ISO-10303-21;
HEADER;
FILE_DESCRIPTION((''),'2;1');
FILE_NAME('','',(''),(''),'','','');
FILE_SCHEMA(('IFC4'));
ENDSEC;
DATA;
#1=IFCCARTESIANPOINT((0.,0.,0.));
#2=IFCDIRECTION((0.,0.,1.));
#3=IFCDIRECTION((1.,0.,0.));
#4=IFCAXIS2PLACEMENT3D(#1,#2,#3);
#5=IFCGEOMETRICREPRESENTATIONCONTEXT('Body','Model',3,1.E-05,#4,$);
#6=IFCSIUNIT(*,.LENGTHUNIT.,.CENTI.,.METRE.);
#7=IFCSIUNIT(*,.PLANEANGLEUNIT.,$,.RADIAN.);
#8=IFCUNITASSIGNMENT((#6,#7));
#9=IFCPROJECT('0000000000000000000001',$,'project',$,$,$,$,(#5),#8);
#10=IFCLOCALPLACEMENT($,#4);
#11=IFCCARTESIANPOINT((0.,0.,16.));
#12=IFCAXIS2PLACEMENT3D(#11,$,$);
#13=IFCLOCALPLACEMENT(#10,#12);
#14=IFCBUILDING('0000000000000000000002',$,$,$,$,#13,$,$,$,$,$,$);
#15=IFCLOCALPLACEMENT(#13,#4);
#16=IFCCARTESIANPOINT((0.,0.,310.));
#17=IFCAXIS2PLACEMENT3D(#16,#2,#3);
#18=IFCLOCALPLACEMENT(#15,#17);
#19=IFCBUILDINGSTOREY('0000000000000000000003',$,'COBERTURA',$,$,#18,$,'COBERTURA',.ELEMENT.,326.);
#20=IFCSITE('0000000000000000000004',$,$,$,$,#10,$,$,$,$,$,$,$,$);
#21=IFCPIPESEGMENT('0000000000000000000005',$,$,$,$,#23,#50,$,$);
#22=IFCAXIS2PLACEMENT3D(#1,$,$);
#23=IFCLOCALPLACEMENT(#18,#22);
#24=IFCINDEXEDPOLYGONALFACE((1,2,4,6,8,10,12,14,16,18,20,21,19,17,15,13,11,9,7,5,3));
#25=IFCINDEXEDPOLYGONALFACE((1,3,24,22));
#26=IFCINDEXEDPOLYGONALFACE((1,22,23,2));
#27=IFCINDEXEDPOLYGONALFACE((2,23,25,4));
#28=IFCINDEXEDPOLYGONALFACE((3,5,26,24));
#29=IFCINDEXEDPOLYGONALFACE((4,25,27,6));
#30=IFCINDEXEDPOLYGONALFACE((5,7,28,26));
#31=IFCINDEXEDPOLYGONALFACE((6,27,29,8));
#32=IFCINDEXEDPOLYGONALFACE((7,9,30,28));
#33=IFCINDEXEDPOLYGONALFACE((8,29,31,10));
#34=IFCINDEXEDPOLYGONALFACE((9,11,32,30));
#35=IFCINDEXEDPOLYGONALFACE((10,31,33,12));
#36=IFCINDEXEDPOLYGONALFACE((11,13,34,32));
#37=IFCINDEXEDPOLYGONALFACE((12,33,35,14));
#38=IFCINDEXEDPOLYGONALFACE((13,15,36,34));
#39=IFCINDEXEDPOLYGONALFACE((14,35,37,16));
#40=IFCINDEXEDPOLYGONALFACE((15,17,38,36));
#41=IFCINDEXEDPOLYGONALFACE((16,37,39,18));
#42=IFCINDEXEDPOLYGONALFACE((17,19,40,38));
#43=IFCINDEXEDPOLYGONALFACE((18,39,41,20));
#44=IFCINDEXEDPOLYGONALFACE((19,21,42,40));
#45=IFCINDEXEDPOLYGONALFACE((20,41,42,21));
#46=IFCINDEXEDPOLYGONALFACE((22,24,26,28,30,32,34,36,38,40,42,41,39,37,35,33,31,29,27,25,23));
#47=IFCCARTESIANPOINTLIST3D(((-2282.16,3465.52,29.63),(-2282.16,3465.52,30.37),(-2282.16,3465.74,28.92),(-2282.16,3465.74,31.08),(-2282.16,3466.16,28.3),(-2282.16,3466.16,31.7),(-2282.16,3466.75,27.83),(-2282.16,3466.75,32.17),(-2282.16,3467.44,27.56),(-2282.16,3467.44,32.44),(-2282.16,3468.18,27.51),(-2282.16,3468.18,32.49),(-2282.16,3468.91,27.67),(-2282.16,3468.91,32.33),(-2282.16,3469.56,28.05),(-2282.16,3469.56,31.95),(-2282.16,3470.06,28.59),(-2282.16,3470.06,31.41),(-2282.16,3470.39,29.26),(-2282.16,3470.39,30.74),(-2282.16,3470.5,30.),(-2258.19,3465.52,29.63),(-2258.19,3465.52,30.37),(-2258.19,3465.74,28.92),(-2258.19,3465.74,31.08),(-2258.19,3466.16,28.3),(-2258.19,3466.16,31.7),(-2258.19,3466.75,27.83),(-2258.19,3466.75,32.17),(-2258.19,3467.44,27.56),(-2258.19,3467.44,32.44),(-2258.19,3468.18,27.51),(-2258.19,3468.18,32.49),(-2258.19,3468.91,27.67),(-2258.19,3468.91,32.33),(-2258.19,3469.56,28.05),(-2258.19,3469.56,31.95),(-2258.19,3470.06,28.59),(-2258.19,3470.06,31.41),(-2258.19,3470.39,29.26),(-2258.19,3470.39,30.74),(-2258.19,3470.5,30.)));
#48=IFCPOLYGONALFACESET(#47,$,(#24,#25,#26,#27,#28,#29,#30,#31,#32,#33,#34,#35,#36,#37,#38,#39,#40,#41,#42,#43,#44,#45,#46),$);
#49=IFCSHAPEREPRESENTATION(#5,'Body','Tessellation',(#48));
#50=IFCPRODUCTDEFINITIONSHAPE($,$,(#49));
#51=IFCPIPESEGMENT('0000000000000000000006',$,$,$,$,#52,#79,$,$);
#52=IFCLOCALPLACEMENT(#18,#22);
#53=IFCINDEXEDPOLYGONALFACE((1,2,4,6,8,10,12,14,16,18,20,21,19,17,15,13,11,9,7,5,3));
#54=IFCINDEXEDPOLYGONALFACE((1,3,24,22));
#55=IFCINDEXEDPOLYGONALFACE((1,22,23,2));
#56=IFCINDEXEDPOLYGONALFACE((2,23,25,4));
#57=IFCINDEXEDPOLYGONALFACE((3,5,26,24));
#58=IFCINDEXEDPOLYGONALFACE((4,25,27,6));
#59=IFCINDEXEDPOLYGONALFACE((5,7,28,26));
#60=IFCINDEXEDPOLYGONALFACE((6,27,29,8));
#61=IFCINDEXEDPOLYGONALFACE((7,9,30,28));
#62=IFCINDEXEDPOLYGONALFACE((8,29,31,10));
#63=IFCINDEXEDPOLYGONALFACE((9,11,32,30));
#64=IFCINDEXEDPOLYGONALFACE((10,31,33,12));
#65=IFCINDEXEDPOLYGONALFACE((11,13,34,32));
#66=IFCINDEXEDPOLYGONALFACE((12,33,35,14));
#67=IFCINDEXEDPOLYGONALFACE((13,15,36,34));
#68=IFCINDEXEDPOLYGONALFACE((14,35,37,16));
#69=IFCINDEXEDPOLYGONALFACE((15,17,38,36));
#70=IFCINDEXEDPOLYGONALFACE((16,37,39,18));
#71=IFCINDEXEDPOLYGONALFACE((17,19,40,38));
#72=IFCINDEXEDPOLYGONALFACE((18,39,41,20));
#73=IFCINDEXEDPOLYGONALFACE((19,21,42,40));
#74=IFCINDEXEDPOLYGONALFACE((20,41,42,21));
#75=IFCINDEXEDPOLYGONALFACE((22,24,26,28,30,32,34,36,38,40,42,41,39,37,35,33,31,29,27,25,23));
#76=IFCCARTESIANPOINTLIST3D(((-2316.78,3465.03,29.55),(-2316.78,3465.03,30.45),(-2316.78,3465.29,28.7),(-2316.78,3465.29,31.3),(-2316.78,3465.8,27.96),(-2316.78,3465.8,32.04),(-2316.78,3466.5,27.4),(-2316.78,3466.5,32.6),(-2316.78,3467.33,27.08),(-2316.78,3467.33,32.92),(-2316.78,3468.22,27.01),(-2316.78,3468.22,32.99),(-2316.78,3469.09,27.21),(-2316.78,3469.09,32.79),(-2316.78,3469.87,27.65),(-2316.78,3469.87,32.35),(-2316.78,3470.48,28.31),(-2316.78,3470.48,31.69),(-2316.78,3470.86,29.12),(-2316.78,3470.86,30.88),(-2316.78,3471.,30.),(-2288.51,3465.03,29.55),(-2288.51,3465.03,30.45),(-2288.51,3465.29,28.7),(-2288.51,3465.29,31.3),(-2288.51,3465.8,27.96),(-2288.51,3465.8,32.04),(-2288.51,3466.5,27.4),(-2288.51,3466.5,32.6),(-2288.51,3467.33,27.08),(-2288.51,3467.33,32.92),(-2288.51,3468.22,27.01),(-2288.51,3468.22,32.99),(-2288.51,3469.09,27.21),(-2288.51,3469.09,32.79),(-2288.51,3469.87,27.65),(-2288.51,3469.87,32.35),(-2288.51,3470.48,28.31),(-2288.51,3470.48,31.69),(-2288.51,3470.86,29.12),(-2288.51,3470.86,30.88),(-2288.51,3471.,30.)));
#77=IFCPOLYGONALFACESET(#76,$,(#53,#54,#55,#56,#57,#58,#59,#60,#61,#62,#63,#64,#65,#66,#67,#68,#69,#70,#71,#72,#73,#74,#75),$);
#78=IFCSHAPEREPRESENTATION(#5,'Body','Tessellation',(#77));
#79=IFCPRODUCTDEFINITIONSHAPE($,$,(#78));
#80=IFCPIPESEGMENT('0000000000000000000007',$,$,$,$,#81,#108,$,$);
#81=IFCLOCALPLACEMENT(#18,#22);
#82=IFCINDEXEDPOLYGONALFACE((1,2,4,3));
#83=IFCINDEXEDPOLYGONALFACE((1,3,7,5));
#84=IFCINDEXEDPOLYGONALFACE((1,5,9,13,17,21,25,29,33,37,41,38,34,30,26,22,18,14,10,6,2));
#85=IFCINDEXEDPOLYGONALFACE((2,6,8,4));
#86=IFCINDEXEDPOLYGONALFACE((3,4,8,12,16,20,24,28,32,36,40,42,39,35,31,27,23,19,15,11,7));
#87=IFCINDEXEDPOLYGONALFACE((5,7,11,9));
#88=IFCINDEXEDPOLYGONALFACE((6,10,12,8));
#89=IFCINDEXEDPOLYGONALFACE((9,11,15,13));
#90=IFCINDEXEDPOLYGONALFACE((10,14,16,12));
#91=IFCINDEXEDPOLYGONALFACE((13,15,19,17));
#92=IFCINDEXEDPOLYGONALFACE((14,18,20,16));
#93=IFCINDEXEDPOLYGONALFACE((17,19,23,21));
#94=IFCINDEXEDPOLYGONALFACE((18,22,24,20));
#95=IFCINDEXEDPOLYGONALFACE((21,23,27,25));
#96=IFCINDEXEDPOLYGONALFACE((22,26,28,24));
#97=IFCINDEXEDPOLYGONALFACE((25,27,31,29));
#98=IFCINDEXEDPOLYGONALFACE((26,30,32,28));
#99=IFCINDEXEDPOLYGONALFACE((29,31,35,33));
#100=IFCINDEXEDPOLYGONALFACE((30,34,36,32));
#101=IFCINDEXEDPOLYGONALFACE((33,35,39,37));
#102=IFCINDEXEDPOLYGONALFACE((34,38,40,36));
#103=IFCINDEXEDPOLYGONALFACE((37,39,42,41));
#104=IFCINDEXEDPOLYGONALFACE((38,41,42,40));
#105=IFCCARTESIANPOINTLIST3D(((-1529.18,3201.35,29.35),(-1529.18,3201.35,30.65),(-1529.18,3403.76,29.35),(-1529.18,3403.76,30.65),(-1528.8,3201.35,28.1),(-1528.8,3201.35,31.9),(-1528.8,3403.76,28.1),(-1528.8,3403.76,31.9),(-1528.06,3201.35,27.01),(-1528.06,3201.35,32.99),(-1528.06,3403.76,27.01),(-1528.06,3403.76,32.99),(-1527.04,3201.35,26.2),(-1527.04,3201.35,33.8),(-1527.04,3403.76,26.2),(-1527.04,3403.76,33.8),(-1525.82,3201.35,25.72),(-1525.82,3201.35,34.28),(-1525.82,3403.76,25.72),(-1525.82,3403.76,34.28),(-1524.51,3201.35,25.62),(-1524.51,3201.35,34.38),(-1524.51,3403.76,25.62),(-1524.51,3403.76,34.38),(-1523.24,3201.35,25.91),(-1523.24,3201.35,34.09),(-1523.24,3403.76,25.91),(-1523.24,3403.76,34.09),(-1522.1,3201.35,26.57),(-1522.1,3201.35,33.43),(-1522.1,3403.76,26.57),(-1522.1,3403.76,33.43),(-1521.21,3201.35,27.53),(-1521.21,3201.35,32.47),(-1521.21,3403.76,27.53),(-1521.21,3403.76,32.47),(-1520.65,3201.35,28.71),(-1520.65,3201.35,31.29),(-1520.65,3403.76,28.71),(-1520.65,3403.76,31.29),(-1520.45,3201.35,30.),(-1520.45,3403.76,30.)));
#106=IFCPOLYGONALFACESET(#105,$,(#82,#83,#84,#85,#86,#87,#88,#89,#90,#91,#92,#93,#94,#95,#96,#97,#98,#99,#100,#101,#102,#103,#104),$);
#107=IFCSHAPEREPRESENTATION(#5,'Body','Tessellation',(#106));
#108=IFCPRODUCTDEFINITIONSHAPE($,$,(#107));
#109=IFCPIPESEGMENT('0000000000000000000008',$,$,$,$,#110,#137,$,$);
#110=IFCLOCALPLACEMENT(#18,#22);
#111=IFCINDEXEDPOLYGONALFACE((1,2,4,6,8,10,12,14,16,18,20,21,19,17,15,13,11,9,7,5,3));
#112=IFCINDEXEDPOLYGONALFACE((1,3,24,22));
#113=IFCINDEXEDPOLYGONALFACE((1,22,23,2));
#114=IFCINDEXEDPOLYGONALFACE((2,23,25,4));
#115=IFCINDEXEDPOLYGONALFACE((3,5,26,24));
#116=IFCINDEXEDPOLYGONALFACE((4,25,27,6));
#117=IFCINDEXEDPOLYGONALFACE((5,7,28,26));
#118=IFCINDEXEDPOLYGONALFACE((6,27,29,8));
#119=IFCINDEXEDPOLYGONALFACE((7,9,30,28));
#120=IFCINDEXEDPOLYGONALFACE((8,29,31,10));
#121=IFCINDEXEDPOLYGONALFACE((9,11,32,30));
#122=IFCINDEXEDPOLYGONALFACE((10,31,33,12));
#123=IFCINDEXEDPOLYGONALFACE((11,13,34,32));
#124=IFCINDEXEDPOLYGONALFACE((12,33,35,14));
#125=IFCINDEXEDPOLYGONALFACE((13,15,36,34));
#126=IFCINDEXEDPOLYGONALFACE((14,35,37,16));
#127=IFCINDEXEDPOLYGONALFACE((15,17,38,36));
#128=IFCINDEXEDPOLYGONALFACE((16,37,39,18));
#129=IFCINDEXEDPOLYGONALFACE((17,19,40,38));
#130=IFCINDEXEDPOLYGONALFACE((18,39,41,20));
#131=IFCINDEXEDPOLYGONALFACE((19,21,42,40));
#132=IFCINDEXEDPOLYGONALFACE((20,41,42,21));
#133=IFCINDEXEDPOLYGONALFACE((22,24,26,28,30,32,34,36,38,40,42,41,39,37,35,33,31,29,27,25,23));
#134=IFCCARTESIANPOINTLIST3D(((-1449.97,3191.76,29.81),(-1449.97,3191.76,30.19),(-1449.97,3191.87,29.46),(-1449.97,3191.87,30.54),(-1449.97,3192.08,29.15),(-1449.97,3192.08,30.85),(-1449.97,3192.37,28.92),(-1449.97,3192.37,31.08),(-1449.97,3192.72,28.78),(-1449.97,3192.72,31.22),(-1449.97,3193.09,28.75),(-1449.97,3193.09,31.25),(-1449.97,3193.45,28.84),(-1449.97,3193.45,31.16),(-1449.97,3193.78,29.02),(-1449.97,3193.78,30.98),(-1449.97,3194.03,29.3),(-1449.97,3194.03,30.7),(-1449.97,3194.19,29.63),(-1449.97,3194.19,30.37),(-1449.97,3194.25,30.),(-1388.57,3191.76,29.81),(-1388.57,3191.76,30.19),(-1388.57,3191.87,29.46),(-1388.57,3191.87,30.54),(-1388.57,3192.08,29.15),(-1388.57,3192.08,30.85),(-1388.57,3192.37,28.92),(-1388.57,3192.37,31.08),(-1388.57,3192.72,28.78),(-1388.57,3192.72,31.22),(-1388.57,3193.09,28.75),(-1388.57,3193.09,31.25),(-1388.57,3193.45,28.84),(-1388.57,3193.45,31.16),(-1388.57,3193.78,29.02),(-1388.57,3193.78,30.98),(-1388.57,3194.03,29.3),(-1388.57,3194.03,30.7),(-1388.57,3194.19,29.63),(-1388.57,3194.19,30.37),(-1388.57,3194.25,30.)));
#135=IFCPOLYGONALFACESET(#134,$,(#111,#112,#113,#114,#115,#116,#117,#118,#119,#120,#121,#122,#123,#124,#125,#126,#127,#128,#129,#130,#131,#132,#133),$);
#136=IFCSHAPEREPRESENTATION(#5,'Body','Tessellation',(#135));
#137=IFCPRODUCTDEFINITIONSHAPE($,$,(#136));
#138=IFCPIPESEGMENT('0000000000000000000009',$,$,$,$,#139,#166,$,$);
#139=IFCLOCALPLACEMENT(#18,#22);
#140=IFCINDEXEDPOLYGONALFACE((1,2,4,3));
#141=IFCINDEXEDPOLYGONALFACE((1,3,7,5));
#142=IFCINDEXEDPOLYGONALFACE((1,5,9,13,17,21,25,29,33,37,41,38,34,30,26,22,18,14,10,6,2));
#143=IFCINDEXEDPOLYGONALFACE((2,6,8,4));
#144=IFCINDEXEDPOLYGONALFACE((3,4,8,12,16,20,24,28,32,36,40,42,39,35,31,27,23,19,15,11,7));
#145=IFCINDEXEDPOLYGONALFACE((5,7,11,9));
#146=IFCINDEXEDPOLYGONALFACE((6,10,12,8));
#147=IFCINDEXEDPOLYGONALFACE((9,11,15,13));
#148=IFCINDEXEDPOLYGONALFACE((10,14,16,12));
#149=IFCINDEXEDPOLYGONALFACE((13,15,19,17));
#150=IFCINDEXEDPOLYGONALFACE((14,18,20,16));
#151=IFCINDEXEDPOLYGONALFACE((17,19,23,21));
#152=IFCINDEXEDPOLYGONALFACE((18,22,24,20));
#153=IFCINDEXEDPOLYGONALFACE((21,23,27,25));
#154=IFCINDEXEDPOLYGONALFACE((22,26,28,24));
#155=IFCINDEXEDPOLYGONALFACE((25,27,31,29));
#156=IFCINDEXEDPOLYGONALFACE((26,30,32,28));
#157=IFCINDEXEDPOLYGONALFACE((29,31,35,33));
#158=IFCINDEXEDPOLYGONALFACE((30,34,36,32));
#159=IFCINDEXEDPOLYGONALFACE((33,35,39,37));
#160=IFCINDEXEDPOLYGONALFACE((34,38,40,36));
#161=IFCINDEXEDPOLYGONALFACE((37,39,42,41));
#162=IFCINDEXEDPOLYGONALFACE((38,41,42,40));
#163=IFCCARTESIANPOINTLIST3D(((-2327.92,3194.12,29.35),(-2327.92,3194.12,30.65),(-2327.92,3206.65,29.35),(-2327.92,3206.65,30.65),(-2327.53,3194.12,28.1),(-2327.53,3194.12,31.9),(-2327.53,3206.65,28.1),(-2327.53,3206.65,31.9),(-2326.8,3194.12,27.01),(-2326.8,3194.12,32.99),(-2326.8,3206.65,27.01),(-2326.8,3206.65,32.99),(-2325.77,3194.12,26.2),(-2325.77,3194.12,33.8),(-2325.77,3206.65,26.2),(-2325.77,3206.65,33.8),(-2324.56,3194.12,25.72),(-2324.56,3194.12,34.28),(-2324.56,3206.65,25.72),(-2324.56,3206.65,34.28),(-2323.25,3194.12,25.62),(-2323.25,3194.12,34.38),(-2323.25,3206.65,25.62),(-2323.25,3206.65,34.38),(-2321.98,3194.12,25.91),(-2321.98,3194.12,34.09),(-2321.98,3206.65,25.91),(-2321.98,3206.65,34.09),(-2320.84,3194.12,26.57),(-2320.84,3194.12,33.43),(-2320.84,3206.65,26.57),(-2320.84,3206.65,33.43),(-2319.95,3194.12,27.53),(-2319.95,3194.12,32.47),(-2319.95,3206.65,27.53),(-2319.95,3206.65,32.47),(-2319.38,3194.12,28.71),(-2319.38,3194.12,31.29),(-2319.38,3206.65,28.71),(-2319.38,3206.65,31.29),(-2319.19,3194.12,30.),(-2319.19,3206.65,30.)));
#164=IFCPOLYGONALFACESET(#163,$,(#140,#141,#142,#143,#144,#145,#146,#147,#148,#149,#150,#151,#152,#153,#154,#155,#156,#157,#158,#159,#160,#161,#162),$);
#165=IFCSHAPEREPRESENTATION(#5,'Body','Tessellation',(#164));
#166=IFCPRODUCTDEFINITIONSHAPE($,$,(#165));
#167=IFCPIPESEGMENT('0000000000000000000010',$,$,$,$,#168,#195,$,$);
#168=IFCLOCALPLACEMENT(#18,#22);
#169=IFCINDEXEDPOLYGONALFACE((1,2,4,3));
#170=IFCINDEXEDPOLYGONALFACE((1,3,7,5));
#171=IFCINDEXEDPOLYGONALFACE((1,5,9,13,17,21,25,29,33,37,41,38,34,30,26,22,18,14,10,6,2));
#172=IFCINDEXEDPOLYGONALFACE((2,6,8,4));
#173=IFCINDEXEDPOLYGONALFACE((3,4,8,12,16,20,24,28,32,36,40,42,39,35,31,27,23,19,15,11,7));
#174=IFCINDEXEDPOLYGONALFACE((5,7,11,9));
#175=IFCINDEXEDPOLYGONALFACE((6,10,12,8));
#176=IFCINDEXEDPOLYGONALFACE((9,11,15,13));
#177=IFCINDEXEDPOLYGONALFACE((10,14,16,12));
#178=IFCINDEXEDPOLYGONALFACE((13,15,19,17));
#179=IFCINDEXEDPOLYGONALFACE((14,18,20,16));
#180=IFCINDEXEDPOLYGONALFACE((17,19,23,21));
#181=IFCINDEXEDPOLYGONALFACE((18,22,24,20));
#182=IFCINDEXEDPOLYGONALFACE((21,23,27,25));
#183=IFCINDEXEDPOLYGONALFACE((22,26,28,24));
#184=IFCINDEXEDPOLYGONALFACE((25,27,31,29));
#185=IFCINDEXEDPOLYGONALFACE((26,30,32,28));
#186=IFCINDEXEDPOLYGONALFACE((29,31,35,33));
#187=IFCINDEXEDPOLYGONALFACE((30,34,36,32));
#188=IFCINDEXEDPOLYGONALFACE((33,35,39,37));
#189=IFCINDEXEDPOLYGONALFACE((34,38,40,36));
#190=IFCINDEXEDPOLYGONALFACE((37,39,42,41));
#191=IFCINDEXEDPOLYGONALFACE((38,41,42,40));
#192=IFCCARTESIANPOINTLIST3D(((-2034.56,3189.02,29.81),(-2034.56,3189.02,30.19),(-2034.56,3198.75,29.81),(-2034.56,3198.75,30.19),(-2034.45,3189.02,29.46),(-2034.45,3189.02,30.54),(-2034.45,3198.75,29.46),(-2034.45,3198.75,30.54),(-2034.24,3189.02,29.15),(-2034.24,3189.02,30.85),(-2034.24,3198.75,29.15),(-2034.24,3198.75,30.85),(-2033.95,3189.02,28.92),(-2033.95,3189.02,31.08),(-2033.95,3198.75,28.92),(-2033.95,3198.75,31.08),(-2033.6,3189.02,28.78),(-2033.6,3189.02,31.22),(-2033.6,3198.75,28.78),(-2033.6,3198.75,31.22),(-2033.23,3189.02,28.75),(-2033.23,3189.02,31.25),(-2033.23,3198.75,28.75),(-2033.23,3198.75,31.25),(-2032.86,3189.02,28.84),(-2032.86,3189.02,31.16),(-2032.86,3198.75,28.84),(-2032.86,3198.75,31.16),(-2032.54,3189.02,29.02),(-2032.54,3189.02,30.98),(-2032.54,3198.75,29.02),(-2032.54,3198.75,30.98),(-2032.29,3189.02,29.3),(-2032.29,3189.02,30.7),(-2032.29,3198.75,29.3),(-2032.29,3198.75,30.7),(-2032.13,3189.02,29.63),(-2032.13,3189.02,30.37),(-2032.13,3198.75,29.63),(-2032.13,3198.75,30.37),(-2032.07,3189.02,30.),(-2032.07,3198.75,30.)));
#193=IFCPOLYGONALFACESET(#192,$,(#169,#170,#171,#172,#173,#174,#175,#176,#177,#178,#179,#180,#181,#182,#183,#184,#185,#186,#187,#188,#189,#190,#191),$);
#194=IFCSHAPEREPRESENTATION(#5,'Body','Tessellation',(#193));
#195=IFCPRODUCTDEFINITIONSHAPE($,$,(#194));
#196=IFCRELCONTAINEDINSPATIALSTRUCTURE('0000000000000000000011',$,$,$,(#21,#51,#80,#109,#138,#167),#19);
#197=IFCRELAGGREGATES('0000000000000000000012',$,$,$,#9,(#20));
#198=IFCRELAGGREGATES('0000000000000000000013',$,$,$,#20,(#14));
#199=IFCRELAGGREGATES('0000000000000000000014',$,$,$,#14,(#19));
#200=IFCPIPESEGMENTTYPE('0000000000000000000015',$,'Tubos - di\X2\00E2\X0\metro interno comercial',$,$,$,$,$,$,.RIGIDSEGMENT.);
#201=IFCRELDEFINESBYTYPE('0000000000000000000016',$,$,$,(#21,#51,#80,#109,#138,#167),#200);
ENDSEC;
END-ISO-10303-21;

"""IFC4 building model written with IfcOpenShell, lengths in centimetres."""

from ifc_helpers import new_model, si_unit, frame, origin_with_axes, origin_2d_with_axis, place, context, project, spatial, circle, extrude, type_object, element, save


model = new_model("IFC4")

# Units and contexts
model_context = context("Model", 3, precision=1e-05, world=origin_with_axes(), identifier="Body")
ifc_project = project(units=[si_unit("LENGTHUNIT", "METRE", prefix="CENTI"), si_unit("PLANEANGLEUNIT", "RADIAN")], contexts=[model_context])

# Site, building, storey
site_placement = place(None, origin_with_axes())
site = spatial("IfcSite", under=ifc_project, at=site_placement)
building_placement = place(site_placement, frame((0.0, 0.0, 16.0)))
building = spatial("IfcBuilding", under=site, at=building_placement)
placement = place(building_placement, origin_with_axes())
storey_placement = place(placement, frame((0.0, 0.0, 310.0), z_axis=(0.0, 0.0, 1.0), x_axis=(1.0, 0.0, 0.0)))
storey = spatial("IfcBuildingStorey", under=building, at=storey_placement, Name="COBERTURA", LongName="COBERTURA", CompositionType="ELEMENT", Elevation=326.0)

# Pipe segments
pipe_segment_type = type_object("IfcPipeSegmentType", Name="Tubos - diâmetro interno comercial", PredefinedType="RIGIDSEGMENT")
pipe_segment_1_placement = place(storey_placement, frame((-2270.18, 3468.0, 32.5), z_axis=(0.0, 0.0, 1.0), x_axis=(1.0, 0.0, 0.0)))
element("IfcPipeSegment", 1, at=pipe_segment_1_placement, inside=storey, type_object=pipe_segment_type, context=model_context, shape_type="SolidModel", body=[
    extrude(circle(Radius=2.5, at=origin_2d_with_axis()), frame((-11.98, 0.0, -2.5), z_axis=(1.0, 0.0, 0.0), x_axis=(0.0, 1.0, 0.0)), (0.0, 0.0, 1.0), 23.97),
])
pipe_segment_2_placement = place(storey_placement, frame((-2302.64, 3468.0, 33.0), z_axis=(0.0, 0.0, 1.0), x_axis=(1.0, 0.0, 0.0)))
element("IfcPipeSegment", 2, at=pipe_segment_2_placement, inside=storey, type_object=pipe_segment_type, context=model_context, shape_type="SolidModel", body=[
    extrude(circle(Radius=3.0, at=origin_2d_with_axis()), frame((-14.13, 0.0, -3.0), z_axis=(1.0, 0.0, 0.0), x_axis=(0.0, 1.0, 0.0)), (0.0, 0.0, 1.0), 28.27),
])
pipe_segment_3_placement = place(storey_placement, frame((-1524.84, 3302.55, 34.39), z_axis=(0.0, 0.0, 1.0), x_axis=(1.0, 0.0, 0.0)))
element("IfcPipeSegment", 3, at=pipe_segment_3_placement, inside=storey, type_object=pipe_segment_type, context=model_context, shape_type="SolidModel", body=[
    extrude(circle(Radius=4.39, at=origin_2d_with_axis()), frame((0.0, -101.21, -4.39), z_axis=(0.0, 1.0, 0.0), x_axis=(1.0, 0.0, 0.0)), (0.0, 0.0, 1.0), 202.41),
])
pipe_segment_4_placement = place(storey_placement, frame((-1419.27, 3193.0, 31.25), z_axis=(0.0, 0.0, 1.0), x_axis=(1.0, 0.0, 0.0)))
element("IfcPipeSegment", 4, at=pipe_segment_4_placement, inside=storey, type_object=pipe_segment_type, context=model_context, shape_type="SolidModel", body=[
    extrude(circle(Radius=1.25, at=origin_2d_with_axis()), frame((-30.7, 0.0, -1.25), z_axis=(1.0, 0.0, 0.0), x_axis=(0.0, 1.0, 0.0)), (0.0, 0.0, 1.0), 61.4),
])
pipe_segment_5_placement = place(storey_placement, frame((-2323.58, 3200.38, 34.39), z_axis=(0.0, 0.0, 1.0), x_axis=(1.0, 0.0, 0.0)))
element("IfcPipeSegment", 5, at=pipe_segment_5_placement, inside=storey, type_object=pipe_segment_type, context=model_context, shape_type="SolidModel", body=[
    extrude(circle(Radius=4.39, at=origin_2d_with_axis()), frame((0.0, -6.26, -4.39), z_axis=(0.0, 1.0, 0.0), x_axis=(1.0, 0.0, 0.0)), (0.0, 0.0, 1.0), 12.52),
])
pipe_segment_6_placement = place(storey_placement, frame((-2033.32, 3193.88, 31.25), z_axis=(0.0, 0.0, 1.0), x_axis=(1.0, 0.0, 0.0)))
element("IfcPipeSegment", 6, at=pipe_segment_6_placement, inside=storey, type_object=pipe_segment_type, context=model_context, shape_type="SolidModel", body=[
    extrude(circle(Radius=1.25, at=origin_2d_with_axis()), frame((0.0, -4.86, -1.25), z_axis=(0.0, 1.0, 0.0), x_axis=(1.0, 0.0, 0.0)), (0.0, 0.0, 1.0), 9.72),
])

save(model, "model.ifc")
